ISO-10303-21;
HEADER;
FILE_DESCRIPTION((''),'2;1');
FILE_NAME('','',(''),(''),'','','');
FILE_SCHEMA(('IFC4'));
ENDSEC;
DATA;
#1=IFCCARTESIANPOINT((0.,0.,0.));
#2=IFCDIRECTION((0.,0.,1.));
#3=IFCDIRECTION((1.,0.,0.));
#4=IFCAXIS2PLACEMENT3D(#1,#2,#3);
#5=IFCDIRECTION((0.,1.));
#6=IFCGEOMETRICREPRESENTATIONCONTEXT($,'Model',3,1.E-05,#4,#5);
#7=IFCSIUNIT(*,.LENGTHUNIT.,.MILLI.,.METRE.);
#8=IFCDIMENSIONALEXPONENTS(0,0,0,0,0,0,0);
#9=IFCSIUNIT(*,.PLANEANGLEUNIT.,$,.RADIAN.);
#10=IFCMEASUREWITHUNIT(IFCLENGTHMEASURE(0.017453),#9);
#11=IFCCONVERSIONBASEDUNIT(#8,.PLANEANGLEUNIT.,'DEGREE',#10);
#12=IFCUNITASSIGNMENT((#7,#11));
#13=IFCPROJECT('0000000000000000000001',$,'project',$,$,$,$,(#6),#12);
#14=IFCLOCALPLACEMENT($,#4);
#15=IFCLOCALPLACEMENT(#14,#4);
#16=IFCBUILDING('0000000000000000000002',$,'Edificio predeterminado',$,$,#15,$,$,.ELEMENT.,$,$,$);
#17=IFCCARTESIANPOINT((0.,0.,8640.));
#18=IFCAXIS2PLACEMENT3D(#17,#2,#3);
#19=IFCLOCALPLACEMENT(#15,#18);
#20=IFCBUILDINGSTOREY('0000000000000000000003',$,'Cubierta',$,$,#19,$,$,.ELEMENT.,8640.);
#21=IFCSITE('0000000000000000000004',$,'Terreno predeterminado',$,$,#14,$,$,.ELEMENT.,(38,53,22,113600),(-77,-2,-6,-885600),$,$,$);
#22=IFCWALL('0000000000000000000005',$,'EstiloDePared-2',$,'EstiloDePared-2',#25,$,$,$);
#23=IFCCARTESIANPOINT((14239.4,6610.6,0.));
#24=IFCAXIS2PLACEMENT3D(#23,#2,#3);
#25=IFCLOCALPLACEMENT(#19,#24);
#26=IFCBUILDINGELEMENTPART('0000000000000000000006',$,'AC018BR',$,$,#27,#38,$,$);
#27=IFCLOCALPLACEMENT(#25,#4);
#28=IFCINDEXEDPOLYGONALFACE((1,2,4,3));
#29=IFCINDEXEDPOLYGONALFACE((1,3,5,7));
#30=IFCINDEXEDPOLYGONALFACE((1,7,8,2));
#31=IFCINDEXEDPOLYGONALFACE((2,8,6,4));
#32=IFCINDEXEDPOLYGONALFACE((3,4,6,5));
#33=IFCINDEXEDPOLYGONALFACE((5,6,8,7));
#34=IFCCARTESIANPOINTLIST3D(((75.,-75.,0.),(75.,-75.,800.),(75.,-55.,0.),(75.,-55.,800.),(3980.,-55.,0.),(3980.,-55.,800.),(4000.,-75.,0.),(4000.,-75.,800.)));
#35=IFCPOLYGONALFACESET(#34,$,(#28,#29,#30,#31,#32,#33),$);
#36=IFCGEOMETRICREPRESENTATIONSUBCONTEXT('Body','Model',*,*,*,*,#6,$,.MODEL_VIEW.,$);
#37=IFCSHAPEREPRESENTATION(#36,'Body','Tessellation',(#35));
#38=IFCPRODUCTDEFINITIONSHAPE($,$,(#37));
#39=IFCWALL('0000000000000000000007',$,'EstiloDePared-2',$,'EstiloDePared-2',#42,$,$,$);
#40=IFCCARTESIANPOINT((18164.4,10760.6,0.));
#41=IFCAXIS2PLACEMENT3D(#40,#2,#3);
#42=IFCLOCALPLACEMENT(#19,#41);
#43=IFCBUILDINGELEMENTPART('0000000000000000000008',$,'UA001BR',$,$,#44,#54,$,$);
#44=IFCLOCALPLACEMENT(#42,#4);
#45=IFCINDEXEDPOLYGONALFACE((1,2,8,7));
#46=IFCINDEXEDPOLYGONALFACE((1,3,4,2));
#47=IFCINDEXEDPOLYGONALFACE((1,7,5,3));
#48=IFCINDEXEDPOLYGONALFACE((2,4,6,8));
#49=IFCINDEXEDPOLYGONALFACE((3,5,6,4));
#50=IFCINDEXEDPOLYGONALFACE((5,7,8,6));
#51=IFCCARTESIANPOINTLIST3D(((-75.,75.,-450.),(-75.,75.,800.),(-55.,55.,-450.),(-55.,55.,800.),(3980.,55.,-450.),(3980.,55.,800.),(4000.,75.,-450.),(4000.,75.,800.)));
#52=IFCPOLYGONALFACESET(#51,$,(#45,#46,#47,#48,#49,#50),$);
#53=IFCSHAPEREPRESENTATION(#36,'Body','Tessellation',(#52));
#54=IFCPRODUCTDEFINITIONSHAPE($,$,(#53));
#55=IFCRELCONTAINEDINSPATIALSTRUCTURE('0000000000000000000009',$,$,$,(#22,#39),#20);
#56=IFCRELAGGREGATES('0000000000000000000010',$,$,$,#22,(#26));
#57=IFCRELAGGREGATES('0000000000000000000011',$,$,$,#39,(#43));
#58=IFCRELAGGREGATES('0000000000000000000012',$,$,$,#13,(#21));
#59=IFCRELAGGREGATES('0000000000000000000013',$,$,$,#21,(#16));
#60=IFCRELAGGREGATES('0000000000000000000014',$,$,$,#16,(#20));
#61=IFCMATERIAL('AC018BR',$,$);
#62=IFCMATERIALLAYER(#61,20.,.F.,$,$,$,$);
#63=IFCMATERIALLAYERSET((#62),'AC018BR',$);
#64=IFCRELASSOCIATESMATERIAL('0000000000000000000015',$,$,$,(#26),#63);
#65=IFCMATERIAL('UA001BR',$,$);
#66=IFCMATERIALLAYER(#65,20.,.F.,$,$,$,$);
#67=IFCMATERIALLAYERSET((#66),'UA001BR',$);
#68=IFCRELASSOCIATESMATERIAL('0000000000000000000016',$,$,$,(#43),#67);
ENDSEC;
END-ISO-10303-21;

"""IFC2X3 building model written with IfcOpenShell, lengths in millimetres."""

from ifc_helpers import new_model, entity, si_unit, converted_unit, direction, frame, origin_with_axes, place, context, subcontext, project, spatial, polyline, outline, extrude, material, layer, layer_set, layer_usage, element, aggregate, save


model = new_model("IFC2X3")

# Units and contexts
model_context = context("Model", 3, precision=1e-05, world=origin_with_axes(), true_north=direction((0.0, 1.0)))
body_context = subcontext(model_context, "Body", "Model", "MODEL_VIEW")
ifc_project = project(units=[si_unit("LENGTHUNIT", "METRE", prefix="MILLI"), converted_unit("PLANEANGLEUNIT", "DEGREE", entity("IfcLengthMeasure", 0.017453), si_unit("PLANEANGLEUNIT", "RADIAN"), dimensions=[0, 0, 0, 0, 0, 0, 0])], contexts=[model_context])

# Site, building, storey
site_placement = place(None, origin_with_axes())
site = spatial("IfcSite", under=ifc_project, at=site_placement, Name="Terreno predeterminado", CompositionType="ELEMENT", RefLatitude=(38, 53, 22, 113600), RefLongitude=(-77, -2, -6, -885600))
building_placement = place(site_placement, origin_with_axes())
building = spatial("IfcBuilding", under=site, at=building_placement, Name="Edificio predeterminado", CompositionType="ELEMENT")
storey_placement = place(building_placement, frame((0.0, 0.0, 8640.0), z_axis=(0.0, 0.0, 1.0), x_axis=(1.0, 0.0, 0.0)))
storey = spatial("IfcBuildingStorey", under=building, at=storey_placement, Name="Cubierta", CompositionType="ELEMENT", Elevation=8640.0)

# Walls, building element parts
wall_1_placement = place(storey_placement, frame((14239.4, 6610.6, 0.0), z_axis=(0.0, 0.0, 1.0), x_axis=(1.0, 0.0, 0.0)))
wall_1 = element("IfcWall", 1, at=wall_1_placement, inside=storey, Name="EstiloDePared-2", ObjectType="EstiloDePared-2")
ifc_material_1 = material(Name="AC018BR")
ifc_layer_1 = layer(ifc_material_1, 20.0, ventilated=False)
ifc_layer_set_1 = layer_set([ifc_layer_1], Name="AC018BR")
ifc_layer_usage_1 = layer_usage(ifc_layer_set_1, "AXIS2", "NEGATIVE", 55.0)
building_element_part_1_placement = place(wall_1_placement, origin_with_axes())
building_element_part_1 = element("IfcBuildingElementPart", 2, at=building_element_part_1_placement, material=ifc_layer_usage_1, Name="AC018BR", context=body_context, shape_type="SweptSolid", body=[
    extrude(outline(polyline([(3980.0, -55.0), (4000.0, -75.0), (75.0, -75.0), (75.0, -55.0), (3980.0, -55.0)])), origin_with_axes(), (0.0, 0.0, 1.0), 800.0),
])
aggregate(wall_1, [building_element_part_1])
wall_2_placement = place(storey_placement, frame((18164.4, 10760.6, 0.0), z_axis=(0.0, 0.0, 1.0), x_axis=(1.0, 0.0, 0.0)))
wall_2 = element("IfcWall", 3, at=wall_2_placement, inside=storey, Name="EstiloDePared-2", ObjectType="EstiloDePared-2")
ifc_material_2 = material(Name="UA001BR")
ifc_layer_2 = layer(ifc_material_2, 20.0, ventilated=False)
ifc_layer_set_2 = layer_set([ifc_layer_2], Name="UA001BR")
ifc_layer_usage_2 = layer_usage(ifc_layer_set_2, "AXIS2", "NEGATIVE", -75.0)
building_element_part_2_placement = place(wall_2_placement, origin_with_axes())
building_element_part_2 = element("IfcBuildingElementPart", 4, at=building_element_part_2_placement, material=ifc_layer_usage_2, Name="UA001BR", context=body_context, shape_type="SweptSolid", body=[
    extrude(outline(polyline([(4000.0, 75.0), (3980.0, 55.0), (-55.0, 55.0), (-75.0, 75.0), (4000.0, 75.0)])), frame((0.0, 0.0, -450.0), z_axis=(0.0, 0.0, 1.0), x_axis=(1.0, 0.0, 0.0)), (0.0, 0.0, 1.0), 1250.0),
])
aggregate(wall_2, [building_element_part_2])

save(model, "model.ifc")
